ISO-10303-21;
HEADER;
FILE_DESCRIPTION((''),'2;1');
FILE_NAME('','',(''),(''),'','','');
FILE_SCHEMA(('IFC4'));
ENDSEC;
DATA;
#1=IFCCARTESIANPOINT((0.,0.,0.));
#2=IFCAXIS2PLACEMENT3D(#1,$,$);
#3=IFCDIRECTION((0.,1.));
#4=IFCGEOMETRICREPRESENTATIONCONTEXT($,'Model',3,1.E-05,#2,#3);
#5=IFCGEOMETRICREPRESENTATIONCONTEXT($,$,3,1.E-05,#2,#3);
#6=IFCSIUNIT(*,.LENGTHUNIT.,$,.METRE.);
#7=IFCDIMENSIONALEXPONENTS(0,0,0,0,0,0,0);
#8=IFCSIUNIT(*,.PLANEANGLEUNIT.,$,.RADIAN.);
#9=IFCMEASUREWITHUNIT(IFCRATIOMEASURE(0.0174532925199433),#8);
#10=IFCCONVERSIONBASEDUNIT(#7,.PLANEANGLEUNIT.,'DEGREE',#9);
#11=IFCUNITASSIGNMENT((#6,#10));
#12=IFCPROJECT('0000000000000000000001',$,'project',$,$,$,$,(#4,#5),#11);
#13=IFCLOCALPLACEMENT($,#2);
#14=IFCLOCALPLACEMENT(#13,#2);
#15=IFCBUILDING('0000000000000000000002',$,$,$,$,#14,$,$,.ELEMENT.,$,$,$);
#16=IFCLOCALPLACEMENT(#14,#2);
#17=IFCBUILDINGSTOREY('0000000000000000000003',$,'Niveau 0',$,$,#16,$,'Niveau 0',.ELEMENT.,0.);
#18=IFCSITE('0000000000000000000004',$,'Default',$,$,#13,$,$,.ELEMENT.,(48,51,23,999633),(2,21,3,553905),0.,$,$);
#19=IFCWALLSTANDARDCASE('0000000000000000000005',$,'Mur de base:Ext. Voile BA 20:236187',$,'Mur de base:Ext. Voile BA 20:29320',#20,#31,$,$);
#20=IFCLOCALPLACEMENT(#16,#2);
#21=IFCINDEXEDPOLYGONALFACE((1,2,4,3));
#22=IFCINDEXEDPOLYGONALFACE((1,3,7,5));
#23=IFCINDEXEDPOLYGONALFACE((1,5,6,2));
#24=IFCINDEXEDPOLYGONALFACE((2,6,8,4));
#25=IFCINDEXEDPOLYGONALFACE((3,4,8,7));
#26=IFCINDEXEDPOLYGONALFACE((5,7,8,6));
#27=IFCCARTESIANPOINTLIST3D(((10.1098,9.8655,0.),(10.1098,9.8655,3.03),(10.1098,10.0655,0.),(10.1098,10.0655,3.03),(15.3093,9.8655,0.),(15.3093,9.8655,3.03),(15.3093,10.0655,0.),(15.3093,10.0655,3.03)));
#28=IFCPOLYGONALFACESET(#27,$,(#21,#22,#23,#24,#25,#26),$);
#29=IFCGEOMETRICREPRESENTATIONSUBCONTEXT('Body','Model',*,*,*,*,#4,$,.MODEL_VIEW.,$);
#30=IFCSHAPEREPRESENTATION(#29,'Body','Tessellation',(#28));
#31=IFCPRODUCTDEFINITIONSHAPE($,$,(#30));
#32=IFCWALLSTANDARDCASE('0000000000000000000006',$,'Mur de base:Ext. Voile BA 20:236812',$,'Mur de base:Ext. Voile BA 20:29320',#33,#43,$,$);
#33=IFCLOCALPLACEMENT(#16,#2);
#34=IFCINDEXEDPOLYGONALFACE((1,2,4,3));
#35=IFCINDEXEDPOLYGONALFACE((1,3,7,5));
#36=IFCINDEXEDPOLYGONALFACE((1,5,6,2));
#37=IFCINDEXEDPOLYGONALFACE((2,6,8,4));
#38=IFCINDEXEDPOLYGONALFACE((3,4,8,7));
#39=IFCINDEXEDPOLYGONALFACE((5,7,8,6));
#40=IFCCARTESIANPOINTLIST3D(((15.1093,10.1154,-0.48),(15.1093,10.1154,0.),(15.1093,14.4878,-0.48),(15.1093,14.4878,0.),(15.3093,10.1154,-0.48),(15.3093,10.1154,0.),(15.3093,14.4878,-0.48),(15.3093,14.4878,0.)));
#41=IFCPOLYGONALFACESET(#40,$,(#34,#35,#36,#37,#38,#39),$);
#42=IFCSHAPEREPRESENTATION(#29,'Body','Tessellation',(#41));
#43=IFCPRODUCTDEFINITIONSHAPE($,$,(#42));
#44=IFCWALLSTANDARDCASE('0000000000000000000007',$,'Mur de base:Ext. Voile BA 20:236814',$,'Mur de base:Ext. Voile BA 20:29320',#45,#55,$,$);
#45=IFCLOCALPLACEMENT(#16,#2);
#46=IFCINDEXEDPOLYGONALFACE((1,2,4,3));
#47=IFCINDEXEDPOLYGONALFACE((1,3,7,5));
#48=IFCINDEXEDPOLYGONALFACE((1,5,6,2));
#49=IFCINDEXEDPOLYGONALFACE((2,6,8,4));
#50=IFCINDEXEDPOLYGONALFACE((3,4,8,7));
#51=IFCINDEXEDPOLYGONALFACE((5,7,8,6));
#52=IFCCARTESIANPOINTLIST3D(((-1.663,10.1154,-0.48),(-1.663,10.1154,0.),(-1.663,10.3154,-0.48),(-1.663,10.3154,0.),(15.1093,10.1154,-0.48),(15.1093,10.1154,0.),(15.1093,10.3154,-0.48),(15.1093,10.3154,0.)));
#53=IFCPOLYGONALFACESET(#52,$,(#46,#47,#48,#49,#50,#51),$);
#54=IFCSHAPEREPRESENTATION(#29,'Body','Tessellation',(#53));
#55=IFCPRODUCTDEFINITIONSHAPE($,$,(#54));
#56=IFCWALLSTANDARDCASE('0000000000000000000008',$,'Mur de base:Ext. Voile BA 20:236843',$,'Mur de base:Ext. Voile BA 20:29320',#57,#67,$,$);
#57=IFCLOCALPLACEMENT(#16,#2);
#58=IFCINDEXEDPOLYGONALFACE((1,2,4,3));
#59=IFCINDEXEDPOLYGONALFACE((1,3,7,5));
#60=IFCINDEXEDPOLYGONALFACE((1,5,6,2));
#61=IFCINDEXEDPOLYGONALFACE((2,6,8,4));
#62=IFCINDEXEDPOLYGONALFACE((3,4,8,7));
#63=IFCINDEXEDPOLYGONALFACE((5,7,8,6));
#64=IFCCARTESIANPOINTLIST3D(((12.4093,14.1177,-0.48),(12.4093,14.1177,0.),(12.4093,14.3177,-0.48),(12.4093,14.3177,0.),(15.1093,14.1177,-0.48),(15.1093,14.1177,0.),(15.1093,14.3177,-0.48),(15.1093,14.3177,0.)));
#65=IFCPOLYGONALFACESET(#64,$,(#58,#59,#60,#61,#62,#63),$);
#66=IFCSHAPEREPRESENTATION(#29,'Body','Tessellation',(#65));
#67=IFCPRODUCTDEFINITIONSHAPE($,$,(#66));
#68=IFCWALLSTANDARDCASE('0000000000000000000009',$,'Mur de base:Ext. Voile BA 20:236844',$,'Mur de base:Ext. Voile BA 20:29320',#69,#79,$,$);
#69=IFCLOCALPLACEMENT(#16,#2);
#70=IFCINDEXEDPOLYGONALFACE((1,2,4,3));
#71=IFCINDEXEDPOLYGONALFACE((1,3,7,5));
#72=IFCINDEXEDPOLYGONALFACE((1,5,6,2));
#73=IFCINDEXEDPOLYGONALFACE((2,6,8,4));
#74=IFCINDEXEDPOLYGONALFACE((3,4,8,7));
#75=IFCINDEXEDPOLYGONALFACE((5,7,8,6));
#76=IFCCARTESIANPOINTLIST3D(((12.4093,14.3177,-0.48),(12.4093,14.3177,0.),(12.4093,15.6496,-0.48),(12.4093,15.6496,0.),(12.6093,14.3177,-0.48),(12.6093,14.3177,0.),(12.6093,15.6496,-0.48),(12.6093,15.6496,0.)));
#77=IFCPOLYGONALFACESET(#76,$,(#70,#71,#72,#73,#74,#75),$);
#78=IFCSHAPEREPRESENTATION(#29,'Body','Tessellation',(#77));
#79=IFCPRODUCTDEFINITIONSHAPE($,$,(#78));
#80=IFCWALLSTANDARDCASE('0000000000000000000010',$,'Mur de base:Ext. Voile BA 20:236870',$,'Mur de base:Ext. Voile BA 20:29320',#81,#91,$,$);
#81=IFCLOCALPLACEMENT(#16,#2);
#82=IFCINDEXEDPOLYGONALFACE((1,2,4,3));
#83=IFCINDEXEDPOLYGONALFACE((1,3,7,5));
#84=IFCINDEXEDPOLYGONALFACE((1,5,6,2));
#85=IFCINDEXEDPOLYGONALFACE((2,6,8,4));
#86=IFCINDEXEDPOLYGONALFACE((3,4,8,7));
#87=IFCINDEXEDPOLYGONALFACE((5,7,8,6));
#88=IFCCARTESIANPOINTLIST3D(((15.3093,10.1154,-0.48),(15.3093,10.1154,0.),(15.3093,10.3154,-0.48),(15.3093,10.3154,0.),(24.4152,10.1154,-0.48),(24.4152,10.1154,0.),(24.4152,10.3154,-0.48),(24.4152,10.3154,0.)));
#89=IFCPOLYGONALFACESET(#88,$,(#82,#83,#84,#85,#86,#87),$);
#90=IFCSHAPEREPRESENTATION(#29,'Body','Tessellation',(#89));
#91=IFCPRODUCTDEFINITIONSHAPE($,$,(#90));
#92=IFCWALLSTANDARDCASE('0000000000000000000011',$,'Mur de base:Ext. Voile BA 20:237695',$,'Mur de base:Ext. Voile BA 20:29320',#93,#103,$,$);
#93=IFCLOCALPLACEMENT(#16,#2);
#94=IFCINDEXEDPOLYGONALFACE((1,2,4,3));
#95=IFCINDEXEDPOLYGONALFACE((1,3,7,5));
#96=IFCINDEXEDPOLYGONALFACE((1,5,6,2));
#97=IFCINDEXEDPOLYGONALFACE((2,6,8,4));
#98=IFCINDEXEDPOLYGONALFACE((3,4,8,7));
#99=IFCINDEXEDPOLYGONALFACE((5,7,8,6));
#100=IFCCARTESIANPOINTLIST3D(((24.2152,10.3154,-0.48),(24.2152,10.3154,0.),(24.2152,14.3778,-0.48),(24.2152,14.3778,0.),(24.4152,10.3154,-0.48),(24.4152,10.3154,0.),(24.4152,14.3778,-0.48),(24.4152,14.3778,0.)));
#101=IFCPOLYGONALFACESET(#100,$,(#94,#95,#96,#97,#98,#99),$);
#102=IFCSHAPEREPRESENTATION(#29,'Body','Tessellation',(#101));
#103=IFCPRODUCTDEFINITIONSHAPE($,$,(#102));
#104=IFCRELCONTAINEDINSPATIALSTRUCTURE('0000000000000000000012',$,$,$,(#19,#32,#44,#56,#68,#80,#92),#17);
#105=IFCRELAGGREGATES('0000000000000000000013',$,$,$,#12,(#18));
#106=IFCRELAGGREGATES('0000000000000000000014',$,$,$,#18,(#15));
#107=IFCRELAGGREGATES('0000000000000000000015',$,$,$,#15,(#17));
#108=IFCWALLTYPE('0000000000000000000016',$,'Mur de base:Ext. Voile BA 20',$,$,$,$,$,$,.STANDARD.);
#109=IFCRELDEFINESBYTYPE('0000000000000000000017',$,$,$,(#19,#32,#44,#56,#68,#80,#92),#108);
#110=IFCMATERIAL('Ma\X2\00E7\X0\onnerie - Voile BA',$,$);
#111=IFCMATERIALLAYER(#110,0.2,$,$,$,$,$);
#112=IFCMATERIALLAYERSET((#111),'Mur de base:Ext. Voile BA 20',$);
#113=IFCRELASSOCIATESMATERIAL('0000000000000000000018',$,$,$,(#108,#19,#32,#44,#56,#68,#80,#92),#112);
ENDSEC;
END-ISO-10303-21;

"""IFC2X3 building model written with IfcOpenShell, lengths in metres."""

from ifc_helpers import new_model, entity, si_unit, converted_unit, direction, frame, frame_2d, origin, place, context, subcontext, project, spatial, rectangle, extrude, material, layer, layer_set, layer_usage, type_object, element, save


model = new_model("IFC2X3")

# Units and contexts
model_context = context("Model", 3, precision=1e-05, world=origin(), true_north=direction((0.0, 1.0)))
context_of_model = context(None, 3, precision=1e-05, world=origin(), true_north=direction((0.0, 1.0)))
body_context = subcontext(model_context, "Body", "Model", "MODEL_VIEW")
ifc_project = project(units=[si_unit("LENGTHUNIT", "METRE"), converted_unit("PLANEANGLEUNIT", "DEGREE", entity("IfcRatioMeasure", 0.0174532925199433), si_unit("PLANEANGLEUNIT", "RADIAN"), dimensions=[0, 0, 0, 0, 0, 0, 0])], contexts=[model_context, context_of_model])

# Site, building, storey
site_placement = place(None, origin())
site = spatial("IfcSite", under=ifc_project, at=site_placement, Name="Default", CompositionType="ELEMENT", RefLatitude=(48, 51, 23, 999633), RefLongitude=(2, 21, 3, 553905), RefElevation=0.0)
building_placement = place(site_placement, origin())
building = spatial("IfcBuilding", under=site, at=building_placement, CompositionType="ELEMENT")
storey_placement = place(building_placement, origin())
storey = spatial("IfcBuildingStorey", under=building, at=storey_placement, Name="Niveau 0", LongName="Niveau 0", CompositionType="ELEMENT", Elevation=0.0)

# Shared definitions
ifc_material_1 = material(Name="Maçonnerie - Voile BA")
ifc_layer = layer(ifc_material_1, 0.2)
ifc_layer_set = layer_set([ifc_layer], Name="Mur de base:Ext. Voile BA 20")
wall_type = type_object("IfcWallType", Name="Mur de base:Ext. Voile BA 20", PredefinedType="STANDARD", material=ifc_layer_set)

# Walls
ifc_layer_usage_1 = layer_usage(ifc_layer_set, "AXIS2", "NEGATIVE", 0.1)
wall_1_placement = place(storey_placement, frame((10.1098, 9.9655, 0.0)))
element("IfcWallStandardCase", 1, at=wall_1_placement, inside=storey, type_object=wall_type, material=ifc_layer_usage_1, Name="Mur de base:Ext. Voile BA 20:236187", ObjectType="Mur de base:Ext. Voile BA 20:29320", context=body_context, shape_type="SweptSolid", body=[
    extrude(rectangle(XDim=5.1996, YDim=0.2, at=frame_2d((2.5998, 0.0), x_axis=(-1.0, 0.0))), origin(), (0.0, 0.0, 1.0), 3.03),
])
ifc_layer_usage_2 = layer_usage(ifc_layer_set, "AXIS2", "NEGATIVE", 0.1)
wall_2_placement = place(storey_placement, frame((15.2093, 14.4878, -0.48), z_axis=(0.0, 0.0, 1.0), x_axis=(0.0, -1.0, 0.0)))
element("IfcWallStandardCase", 2, at=wall_2_placement, inside=storey, type_object=wall_type, material=ifc_layer_usage_2, Name="Mur de base:Ext. Voile BA 20:236812", ObjectType="Mur de base:Ext. Voile BA 20:29320", context=body_context, shape_type="SweptSolid", body=[
    extrude(rectangle(XDim=4.3724, YDim=0.2, at=frame_2d((2.1862, 0.0), x_axis=(-1.0, 0.0))), origin(), (0.0, 0.0, 1.0), 0.48),
])
ifc_layer_usage_3 = layer_usage(ifc_layer_set, "AXIS2", "NEGATIVE", 0.1)
wall_3_placement = place(storey_placement, frame((15.1093, 10.2154, -0.48), z_axis=(0.0, 0.0, 1.0), x_axis=(-1.0, 0.0, 0.0)))
element("IfcWallStandardCase", 3, at=wall_3_placement, inside=storey, type_object=wall_type, material=ifc_layer_usage_3, Name="Mur de base:Ext. Voile BA 20:236814", ObjectType="Mur de base:Ext. Voile BA 20:29320", context=body_context, shape_type="SweptSolid", body=[
    extrude(rectangle(XDim=16.7723, YDim=0.2, at=frame_2d((8.3862, 0.0), x_axis=(-1.0, 0.0))), origin(), (0.0, 0.0, 1.0), 0.48),
])
ifc_layer_usage_4 = layer_usage(ifc_layer_set, "AXIS2", "NEGATIVE", 0.1)
wall_4_placement = place(storey_placement, frame((15.1093, 14.2177, -0.48), z_axis=(0.0, 0.0, 1.0), x_axis=(-1.0, 0.0, 0.0)))
element("IfcWallStandardCase", 4, at=wall_4_placement, inside=storey, type_object=wall_type, material=ifc_layer_usage_4, Name="Mur de base:Ext. Voile BA 20:236843", ObjectType="Mur de base:Ext. Voile BA 20:29320", context=body_context, shape_type="SweptSolid", body=[
    extrude(rectangle(XDim=2.7, YDim=0.2, at=frame_2d((1.35, 0.0), x_axis=(-1.0, 0.0))), origin(), (0.0, 0.0, 1.0), 0.48),
])
ifc_layer_usage_5 = layer_usage(ifc_layer_set, "AXIS2", "NEGATIVE", 0.1)
wall_5_placement = place(storey_placement, frame((12.5093, 14.3177, -0.48), z_axis=(0.0, 0.0, 1.0), x_axis=(0.0, 1.0, 0.0)))
element("IfcWallStandardCase", 5, at=wall_5_placement, inside=storey, type_object=wall_type, material=ifc_layer_usage_5, Name="Mur de base:Ext. Voile BA 20:236844", ObjectType="Mur de base:Ext. Voile BA 20:29320", context=body_context, shape_type="SweptSolid", body=[
    extrude(rectangle(XDim=1.3319, YDim=0.2, at=frame_2d((0.666, 0.0), x_axis=(-1.0, 0.0))), origin(), (0.0, 0.0, 1.0), 0.48),
])
ifc_layer_usage_6 = layer_usage(ifc_layer_set, "AXIS2", "NEGATIVE", 0.1)
wall_6_placement = place(storey_placement, frame((15.3093, 10.2154, -0.48)))
element("IfcWallStandardCase", 6, at=wall_6_placement, inside=storey, type_object=wall_type, material=ifc_layer_usage_6, Name="Mur de base:Ext. Voile BA 20:236870", ObjectType="Mur de base:Ext. Voile BA 20:29320", context=body_context, shape_type="SweptSolid", body=[
    extrude(rectangle(XDim=9.1059, YDim=0.2, at=frame_2d((4.553, 0.0), x_axis=(-1.0, 0.0))), origin(), (0.0, 0.0, 1.0), 0.48),
])
ifc_layer_usage_7 = layer_usage(ifc_layer_set, "AXIS2", "NEGATIVE", 0.1)
wall_7_placement = place(storey_placement, frame((24.3152, 14.3778, -0.48), z_axis=(0.0, 0.0, 1.0), x_axis=(0.0, -1.0, 0.0)))
element("IfcWallStandardCase", 7, at=wall_7_placement, inside=storey, type_object=wall_type, material=ifc_layer_usage_7, Name="Mur de base:Ext. Voile BA 20:237695", ObjectType="Mur de base:Ext. Voile BA 20:29320", context=body_context, shape_type="SweptSolid", body=[
    extrude(rectangle(XDim=4.0623, YDim=0.2, at=frame_2d((2.0312, 0.0), x_axis=(-1.0, 0.0))), origin(), (0.0, 0.0, 1.0), 0.48),
])

save(model, "model.ifc")
